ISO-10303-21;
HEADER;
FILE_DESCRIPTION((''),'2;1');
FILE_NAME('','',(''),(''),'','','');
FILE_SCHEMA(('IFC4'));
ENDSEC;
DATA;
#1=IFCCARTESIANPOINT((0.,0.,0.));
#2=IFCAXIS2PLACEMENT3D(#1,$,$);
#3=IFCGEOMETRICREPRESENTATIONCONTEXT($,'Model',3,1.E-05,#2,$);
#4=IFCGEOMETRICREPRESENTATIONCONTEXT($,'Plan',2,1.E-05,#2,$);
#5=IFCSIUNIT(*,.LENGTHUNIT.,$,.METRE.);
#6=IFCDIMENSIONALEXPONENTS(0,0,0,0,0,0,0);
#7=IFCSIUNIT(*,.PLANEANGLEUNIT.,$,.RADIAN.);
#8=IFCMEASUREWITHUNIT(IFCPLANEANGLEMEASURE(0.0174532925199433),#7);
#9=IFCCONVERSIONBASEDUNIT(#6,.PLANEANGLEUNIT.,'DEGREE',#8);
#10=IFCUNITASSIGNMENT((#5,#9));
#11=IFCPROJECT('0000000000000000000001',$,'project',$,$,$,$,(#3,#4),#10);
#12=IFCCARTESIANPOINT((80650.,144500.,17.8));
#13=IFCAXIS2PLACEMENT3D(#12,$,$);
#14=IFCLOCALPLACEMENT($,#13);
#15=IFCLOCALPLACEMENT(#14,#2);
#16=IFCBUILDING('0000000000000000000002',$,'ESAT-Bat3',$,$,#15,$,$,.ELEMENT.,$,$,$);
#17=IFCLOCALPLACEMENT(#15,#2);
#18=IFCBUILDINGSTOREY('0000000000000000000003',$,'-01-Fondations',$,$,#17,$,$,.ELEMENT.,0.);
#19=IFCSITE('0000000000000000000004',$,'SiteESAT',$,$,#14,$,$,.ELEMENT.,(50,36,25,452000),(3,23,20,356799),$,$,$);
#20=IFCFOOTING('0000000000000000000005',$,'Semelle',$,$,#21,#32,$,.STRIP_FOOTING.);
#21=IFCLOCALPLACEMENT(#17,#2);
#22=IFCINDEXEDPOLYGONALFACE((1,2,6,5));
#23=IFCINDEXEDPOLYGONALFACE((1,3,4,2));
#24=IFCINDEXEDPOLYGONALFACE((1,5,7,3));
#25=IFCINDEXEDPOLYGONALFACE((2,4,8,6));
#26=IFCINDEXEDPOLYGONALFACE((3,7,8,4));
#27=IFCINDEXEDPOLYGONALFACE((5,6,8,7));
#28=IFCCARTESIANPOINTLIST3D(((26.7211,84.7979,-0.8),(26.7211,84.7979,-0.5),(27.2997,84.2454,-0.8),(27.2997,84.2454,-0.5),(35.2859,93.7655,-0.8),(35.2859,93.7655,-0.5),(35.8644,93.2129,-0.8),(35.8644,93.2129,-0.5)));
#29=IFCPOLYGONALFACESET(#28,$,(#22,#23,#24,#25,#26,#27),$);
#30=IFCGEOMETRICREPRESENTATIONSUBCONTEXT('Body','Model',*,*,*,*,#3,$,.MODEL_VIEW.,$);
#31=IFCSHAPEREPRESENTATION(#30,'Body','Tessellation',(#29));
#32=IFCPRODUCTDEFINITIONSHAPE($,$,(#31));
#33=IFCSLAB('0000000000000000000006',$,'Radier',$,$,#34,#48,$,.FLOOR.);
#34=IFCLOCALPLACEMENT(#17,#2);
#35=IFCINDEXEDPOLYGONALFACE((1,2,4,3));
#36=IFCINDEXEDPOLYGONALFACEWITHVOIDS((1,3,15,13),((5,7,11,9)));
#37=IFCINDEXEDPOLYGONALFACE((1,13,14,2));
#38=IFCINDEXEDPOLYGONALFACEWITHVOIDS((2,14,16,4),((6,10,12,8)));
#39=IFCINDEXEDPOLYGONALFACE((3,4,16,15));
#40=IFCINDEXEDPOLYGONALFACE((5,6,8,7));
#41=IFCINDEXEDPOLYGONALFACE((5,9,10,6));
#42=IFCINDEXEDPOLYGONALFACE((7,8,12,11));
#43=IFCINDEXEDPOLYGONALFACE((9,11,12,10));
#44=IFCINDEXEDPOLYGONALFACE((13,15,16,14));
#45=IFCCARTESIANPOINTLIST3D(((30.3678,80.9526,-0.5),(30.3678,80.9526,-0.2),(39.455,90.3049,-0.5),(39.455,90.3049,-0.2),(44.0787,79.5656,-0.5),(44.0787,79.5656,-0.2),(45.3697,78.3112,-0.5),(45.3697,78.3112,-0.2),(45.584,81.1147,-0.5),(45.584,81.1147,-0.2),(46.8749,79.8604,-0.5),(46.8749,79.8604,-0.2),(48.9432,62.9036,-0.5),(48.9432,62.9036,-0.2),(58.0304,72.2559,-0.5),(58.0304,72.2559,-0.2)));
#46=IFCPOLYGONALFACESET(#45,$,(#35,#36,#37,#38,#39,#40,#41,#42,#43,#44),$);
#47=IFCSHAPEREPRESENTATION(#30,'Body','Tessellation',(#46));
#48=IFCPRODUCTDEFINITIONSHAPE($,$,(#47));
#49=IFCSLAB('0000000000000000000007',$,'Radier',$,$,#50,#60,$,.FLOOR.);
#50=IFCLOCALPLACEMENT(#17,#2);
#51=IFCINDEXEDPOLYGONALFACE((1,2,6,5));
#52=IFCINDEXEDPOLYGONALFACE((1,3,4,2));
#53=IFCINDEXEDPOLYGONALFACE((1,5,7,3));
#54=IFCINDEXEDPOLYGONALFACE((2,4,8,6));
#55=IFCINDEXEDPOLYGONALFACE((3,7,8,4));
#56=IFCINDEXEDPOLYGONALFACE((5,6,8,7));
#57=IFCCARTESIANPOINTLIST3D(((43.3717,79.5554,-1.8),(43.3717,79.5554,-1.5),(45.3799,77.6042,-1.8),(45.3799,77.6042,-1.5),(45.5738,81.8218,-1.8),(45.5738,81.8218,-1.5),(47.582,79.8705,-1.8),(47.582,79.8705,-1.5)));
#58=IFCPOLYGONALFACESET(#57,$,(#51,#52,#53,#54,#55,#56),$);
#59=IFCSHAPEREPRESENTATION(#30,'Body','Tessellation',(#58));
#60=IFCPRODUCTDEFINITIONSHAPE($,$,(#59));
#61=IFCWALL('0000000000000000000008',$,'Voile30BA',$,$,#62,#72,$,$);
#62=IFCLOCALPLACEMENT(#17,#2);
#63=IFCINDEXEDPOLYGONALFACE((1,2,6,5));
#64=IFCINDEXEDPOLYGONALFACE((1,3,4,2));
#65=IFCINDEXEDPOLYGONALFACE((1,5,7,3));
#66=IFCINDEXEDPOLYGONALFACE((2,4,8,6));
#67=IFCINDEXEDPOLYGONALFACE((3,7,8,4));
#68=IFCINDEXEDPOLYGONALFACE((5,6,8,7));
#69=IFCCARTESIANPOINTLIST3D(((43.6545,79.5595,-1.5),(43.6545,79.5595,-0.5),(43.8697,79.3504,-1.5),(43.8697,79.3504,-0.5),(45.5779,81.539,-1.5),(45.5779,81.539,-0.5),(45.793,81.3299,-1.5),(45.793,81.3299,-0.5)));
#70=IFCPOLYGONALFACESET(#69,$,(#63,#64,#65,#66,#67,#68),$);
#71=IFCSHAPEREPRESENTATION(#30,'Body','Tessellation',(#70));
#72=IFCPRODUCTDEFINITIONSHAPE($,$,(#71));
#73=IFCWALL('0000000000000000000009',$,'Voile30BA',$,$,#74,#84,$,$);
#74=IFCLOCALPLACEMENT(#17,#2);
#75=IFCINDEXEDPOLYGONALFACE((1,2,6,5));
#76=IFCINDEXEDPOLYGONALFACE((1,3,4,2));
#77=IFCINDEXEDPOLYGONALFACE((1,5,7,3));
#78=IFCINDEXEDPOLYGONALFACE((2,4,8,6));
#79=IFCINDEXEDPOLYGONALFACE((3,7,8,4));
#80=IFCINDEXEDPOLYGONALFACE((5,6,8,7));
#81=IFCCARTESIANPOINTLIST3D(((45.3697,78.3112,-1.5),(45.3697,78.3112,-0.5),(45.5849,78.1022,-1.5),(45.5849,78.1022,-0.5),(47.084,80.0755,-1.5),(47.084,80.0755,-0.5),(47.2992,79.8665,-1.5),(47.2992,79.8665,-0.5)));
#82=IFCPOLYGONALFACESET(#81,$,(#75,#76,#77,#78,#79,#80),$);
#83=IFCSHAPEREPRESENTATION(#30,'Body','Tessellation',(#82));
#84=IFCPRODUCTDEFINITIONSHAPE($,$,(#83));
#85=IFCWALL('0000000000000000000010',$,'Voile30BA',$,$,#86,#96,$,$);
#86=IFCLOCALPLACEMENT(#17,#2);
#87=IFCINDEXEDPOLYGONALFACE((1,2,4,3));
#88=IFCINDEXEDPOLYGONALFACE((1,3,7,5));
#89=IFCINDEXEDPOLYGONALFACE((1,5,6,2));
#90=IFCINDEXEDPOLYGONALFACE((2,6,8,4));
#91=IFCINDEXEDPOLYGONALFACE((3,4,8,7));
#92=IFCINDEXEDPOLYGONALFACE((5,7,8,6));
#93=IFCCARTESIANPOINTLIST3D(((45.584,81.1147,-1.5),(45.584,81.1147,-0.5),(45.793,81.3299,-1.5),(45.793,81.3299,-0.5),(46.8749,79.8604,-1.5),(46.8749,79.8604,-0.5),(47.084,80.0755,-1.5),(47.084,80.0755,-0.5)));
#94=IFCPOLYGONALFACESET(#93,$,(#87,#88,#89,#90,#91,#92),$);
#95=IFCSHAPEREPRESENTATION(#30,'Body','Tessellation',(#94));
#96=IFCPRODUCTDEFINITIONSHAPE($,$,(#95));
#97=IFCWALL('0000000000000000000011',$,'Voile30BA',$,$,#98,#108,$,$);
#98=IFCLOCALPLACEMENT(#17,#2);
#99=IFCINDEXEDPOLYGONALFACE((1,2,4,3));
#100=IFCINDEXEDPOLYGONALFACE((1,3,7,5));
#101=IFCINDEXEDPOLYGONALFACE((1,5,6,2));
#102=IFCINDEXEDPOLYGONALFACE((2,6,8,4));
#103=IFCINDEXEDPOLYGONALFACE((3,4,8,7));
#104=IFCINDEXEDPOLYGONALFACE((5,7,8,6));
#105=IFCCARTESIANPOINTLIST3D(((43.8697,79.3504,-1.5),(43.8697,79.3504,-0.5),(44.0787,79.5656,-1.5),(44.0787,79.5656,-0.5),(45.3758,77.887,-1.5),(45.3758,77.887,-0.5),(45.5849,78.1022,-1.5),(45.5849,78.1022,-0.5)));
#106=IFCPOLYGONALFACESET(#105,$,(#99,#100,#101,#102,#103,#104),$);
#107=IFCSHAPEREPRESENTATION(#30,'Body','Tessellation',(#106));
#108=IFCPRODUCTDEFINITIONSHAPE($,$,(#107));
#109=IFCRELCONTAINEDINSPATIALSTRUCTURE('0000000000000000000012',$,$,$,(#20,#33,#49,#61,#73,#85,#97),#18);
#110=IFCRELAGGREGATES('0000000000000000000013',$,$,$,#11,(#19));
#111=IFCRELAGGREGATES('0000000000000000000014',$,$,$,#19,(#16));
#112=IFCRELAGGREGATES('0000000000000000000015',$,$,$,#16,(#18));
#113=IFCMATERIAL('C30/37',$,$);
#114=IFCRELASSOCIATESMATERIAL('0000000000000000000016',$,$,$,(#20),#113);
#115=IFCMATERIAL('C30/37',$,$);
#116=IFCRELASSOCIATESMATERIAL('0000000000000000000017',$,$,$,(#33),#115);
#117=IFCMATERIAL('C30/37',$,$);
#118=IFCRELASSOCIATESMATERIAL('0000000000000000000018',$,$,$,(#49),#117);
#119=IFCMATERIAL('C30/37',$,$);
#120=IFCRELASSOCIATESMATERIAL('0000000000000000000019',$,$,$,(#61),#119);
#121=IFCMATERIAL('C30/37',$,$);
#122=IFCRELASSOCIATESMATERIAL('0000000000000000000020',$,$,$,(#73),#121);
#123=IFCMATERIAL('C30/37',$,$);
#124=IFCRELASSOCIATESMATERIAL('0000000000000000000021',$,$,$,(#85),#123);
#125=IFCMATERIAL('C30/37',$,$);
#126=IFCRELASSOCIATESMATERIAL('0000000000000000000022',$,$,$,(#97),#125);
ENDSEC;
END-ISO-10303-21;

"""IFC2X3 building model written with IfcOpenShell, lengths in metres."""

from ifc_helpers import new_model, entity, si_unit, converted_unit, frame, frame_2d, origin, origin_with_axes, place, context, subcontext, project, spatial, polyline, rectangle, outline, extrude, material, element, save


model = new_model("IFC2X3")

# Units and contexts
model_context = context("Model", 3, precision=1e-05, world=origin())
plan_context = context("Plan", 2, precision=1e-05, world=origin())
body_context = subcontext(model_context, "Body", "Model", "MODEL_VIEW")
ifc_project = project(units=[si_unit("LENGTHUNIT", "METRE"), converted_unit("PLANEANGLEUNIT", "DEGREE", entity("IfcPlaneAngleMeasure", 0.0174532925199433), si_unit("PLANEANGLEUNIT", "RADIAN"), dimensions=[0, 0, 0, 0, 0, 0, 0])], contexts=[model_context, plan_context])

# Site, building, storey
site_placement = place(None, frame((80650.0, 144500.0, 17.8)))
site = spatial("IfcSite", under=ifc_project, at=site_placement, Name="SiteESAT", CompositionType="ELEMENT", RefLatitude=(50, 36, 25, 452000), RefLongitude=(3, 23, 20, 356799))
building_placement = place(site_placement, origin())
building = spatial("IfcBuilding", under=site, at=building_placement, Name="ESAT-Bat3", CompositionType="ELEMENT")
storey_placement = place(building_placement, origin())
storey = spatial("IfcBuildingStorey", under=building, at=storey_placement, Name="-01-Fondations", CompositionType="ELEMENT", Elevation=0.0)

# Footing
ifc_material_1 = material(Name="C30/37")
footing_placement = place(storey_placement, frame((27.2997, 84.2454, -0.8), z_axis=(0.0, 0.0, 1.0), x_axis=(0.690677, 0.723163, 0.0)))
element("IfcFooting", 1, at=footing_placement, inside=storey, material=ifc_material_1, Name="Semelle", PredefinedType="STRIP_FOOTING", context=body_context, shape_type="SweptSolid", body=[
    extrude(rectangle(XDim=0.8, YDim=0.3, at=frame_2d((0.4, 0.15), x_axis=(1.0, 0.0))), frame((0.0, 0.0, 0.0), z_axis=(1.0, 0.0, 0.0), x_axis=(0.0, 1.0, 0.0)), (0.0, 0.0, 1.0), 12.4005),
])

# Slabs
ifc_material_2 = material(Name="C30/37")
slab_1_placement = place(storey_placement, frame((30.3678, 62.9036, -0.5)))
element("IfcSlab", 2, at=slab_1_placement, inside=storey, material=ifc_material_2, Name="Radier", PredefinedType="FLOOR", context=body_context, shape_type="SweptSolid", body=[
    extrude(outline(polyline([(18.5754, 0.0), (27.6626, 9.3522), (9.0872, 27.4012), (0.0, 18.049), (18.5754, 0.0)]), holes=[polyline([(16.5071, 16.9567), (15.0019, 15.4076), (13.7109, 16.662), (15.2162, 18.2111), (16.5071, 16.9567)])]), origin_with_axes(), (0.0, 0.0, 1.0), 0.3),
])
ifc_material_3 = material(Name="C30/37")
slab_2_placement = place(storey_placement, frame((43.3717, 77.6042, -1.8)))
element("IfcSlab", 3, at=slab_2_placement, inside=storey, material=ifc_material_3, Name="Radier", PredefinedType="FLOOR", context=body_context, shape_type="SweptSolid", body=[
    extrude(rectangle(XDim=2.8, YDim=3.16, at=frame_2d((2.1051, 0.1575), x_axis=(0.717196, -0.696872))), frame((0.0, 1.9512, 0.0), z_axis=(0.0, 0.0, 1.0), x_axis=(1.0, 0.0, 0.0)), (0.0, 0.0, 1.0), 0.3),
])

# Walls
ifc_material_4 = material(Name="C30/37")
wall_1_placement = place(storey_placement, frame((43.8697, 79.3504, -1.5), z_axis=(0.0, 0.0, 1.0), x_axis=(0.696872, 0.717196, 0.0)))
element("IfcWall", 4, at=wall_1_placement, inside=storey, material=ifc_material_4, Name="Voile30BA", context=body_context, shape_type="SweptSolid", body=[
    extrude(rectangle(XDim=2.76, YDim=0.3, at=frame_2d((1.38, 0.15), x_axis=(1.0, 0.0))), origin_with_axes(), (0.0, 0.0, 1.0), 1.0),
])
ifc_material_5 = material(Name="C30/37")
wall_2_placement = place(storey_placement, frame((47.084, 80.0755, -1.5), z_axis=(0.0, 0.0, 1.0), x_axis=(-0.696872, -0.717196, 0.0)))
element("IfcWall", 5, at=wall_2_placement, inside=storey, material=ifc_material_5, Name="Voile30BA", context=body_context, shape_type="SweptSolid", body=[
    extrude(rectangle(XDim=2.46, YDim=0.3, at=frame_2d((1.23, 0.15), x_axis=(1.0, 0.0))), origin_with_axes(), (0.0, 0.0, 1.0), 1.0),
])
ifc_material_6 = material(Name="C30/37")
wall_3_placement = place(storey_placement, frame((45.584, 81.1147, -1.5), z_axis=(0.0, 0.0, 1.0), x_axis=(0.717196, -0.696872, 0.0)))
element("IfcWall", 6, at=wall_3_placement, inside=storey, material=ifc_material_6, Name="Voile30BA", context=body_context, shape_type="SweptSolid", body=[
    extrude(rectangle(XDim=1.8, YDim=0.3, at=frame_2d((0.9, 0.15), x_axis=(1.0, 0.0))), origin_with_axes(), (0.0, 0.0, 1.0), 1.0),
])
ifc_material_7 = material(Name="C30/37")
wall_4_placement = place(storey_placement, frame((45.5849, 78.1022, -1.5), z_axis=(0.0, 0.0, 1.0), x_axis=(-0.717196, 0.696872, 0.0)))
element("IfcWall", 7, at=wall_4_placement, inside=storey, material=ifc_material_7, Name="Voile30BA", context=body_context, shape_type="SweptSolid", body=[
    extrude(rectangle(XDim=2.1, YDim=0.3, at=frame_2d((1.05, 0.15), x_axis=(1.0, 0.0))), origin_with_axes(), (0.0, 0.0, 1.0), 1.0),
])

save(model, "model.ifc")
